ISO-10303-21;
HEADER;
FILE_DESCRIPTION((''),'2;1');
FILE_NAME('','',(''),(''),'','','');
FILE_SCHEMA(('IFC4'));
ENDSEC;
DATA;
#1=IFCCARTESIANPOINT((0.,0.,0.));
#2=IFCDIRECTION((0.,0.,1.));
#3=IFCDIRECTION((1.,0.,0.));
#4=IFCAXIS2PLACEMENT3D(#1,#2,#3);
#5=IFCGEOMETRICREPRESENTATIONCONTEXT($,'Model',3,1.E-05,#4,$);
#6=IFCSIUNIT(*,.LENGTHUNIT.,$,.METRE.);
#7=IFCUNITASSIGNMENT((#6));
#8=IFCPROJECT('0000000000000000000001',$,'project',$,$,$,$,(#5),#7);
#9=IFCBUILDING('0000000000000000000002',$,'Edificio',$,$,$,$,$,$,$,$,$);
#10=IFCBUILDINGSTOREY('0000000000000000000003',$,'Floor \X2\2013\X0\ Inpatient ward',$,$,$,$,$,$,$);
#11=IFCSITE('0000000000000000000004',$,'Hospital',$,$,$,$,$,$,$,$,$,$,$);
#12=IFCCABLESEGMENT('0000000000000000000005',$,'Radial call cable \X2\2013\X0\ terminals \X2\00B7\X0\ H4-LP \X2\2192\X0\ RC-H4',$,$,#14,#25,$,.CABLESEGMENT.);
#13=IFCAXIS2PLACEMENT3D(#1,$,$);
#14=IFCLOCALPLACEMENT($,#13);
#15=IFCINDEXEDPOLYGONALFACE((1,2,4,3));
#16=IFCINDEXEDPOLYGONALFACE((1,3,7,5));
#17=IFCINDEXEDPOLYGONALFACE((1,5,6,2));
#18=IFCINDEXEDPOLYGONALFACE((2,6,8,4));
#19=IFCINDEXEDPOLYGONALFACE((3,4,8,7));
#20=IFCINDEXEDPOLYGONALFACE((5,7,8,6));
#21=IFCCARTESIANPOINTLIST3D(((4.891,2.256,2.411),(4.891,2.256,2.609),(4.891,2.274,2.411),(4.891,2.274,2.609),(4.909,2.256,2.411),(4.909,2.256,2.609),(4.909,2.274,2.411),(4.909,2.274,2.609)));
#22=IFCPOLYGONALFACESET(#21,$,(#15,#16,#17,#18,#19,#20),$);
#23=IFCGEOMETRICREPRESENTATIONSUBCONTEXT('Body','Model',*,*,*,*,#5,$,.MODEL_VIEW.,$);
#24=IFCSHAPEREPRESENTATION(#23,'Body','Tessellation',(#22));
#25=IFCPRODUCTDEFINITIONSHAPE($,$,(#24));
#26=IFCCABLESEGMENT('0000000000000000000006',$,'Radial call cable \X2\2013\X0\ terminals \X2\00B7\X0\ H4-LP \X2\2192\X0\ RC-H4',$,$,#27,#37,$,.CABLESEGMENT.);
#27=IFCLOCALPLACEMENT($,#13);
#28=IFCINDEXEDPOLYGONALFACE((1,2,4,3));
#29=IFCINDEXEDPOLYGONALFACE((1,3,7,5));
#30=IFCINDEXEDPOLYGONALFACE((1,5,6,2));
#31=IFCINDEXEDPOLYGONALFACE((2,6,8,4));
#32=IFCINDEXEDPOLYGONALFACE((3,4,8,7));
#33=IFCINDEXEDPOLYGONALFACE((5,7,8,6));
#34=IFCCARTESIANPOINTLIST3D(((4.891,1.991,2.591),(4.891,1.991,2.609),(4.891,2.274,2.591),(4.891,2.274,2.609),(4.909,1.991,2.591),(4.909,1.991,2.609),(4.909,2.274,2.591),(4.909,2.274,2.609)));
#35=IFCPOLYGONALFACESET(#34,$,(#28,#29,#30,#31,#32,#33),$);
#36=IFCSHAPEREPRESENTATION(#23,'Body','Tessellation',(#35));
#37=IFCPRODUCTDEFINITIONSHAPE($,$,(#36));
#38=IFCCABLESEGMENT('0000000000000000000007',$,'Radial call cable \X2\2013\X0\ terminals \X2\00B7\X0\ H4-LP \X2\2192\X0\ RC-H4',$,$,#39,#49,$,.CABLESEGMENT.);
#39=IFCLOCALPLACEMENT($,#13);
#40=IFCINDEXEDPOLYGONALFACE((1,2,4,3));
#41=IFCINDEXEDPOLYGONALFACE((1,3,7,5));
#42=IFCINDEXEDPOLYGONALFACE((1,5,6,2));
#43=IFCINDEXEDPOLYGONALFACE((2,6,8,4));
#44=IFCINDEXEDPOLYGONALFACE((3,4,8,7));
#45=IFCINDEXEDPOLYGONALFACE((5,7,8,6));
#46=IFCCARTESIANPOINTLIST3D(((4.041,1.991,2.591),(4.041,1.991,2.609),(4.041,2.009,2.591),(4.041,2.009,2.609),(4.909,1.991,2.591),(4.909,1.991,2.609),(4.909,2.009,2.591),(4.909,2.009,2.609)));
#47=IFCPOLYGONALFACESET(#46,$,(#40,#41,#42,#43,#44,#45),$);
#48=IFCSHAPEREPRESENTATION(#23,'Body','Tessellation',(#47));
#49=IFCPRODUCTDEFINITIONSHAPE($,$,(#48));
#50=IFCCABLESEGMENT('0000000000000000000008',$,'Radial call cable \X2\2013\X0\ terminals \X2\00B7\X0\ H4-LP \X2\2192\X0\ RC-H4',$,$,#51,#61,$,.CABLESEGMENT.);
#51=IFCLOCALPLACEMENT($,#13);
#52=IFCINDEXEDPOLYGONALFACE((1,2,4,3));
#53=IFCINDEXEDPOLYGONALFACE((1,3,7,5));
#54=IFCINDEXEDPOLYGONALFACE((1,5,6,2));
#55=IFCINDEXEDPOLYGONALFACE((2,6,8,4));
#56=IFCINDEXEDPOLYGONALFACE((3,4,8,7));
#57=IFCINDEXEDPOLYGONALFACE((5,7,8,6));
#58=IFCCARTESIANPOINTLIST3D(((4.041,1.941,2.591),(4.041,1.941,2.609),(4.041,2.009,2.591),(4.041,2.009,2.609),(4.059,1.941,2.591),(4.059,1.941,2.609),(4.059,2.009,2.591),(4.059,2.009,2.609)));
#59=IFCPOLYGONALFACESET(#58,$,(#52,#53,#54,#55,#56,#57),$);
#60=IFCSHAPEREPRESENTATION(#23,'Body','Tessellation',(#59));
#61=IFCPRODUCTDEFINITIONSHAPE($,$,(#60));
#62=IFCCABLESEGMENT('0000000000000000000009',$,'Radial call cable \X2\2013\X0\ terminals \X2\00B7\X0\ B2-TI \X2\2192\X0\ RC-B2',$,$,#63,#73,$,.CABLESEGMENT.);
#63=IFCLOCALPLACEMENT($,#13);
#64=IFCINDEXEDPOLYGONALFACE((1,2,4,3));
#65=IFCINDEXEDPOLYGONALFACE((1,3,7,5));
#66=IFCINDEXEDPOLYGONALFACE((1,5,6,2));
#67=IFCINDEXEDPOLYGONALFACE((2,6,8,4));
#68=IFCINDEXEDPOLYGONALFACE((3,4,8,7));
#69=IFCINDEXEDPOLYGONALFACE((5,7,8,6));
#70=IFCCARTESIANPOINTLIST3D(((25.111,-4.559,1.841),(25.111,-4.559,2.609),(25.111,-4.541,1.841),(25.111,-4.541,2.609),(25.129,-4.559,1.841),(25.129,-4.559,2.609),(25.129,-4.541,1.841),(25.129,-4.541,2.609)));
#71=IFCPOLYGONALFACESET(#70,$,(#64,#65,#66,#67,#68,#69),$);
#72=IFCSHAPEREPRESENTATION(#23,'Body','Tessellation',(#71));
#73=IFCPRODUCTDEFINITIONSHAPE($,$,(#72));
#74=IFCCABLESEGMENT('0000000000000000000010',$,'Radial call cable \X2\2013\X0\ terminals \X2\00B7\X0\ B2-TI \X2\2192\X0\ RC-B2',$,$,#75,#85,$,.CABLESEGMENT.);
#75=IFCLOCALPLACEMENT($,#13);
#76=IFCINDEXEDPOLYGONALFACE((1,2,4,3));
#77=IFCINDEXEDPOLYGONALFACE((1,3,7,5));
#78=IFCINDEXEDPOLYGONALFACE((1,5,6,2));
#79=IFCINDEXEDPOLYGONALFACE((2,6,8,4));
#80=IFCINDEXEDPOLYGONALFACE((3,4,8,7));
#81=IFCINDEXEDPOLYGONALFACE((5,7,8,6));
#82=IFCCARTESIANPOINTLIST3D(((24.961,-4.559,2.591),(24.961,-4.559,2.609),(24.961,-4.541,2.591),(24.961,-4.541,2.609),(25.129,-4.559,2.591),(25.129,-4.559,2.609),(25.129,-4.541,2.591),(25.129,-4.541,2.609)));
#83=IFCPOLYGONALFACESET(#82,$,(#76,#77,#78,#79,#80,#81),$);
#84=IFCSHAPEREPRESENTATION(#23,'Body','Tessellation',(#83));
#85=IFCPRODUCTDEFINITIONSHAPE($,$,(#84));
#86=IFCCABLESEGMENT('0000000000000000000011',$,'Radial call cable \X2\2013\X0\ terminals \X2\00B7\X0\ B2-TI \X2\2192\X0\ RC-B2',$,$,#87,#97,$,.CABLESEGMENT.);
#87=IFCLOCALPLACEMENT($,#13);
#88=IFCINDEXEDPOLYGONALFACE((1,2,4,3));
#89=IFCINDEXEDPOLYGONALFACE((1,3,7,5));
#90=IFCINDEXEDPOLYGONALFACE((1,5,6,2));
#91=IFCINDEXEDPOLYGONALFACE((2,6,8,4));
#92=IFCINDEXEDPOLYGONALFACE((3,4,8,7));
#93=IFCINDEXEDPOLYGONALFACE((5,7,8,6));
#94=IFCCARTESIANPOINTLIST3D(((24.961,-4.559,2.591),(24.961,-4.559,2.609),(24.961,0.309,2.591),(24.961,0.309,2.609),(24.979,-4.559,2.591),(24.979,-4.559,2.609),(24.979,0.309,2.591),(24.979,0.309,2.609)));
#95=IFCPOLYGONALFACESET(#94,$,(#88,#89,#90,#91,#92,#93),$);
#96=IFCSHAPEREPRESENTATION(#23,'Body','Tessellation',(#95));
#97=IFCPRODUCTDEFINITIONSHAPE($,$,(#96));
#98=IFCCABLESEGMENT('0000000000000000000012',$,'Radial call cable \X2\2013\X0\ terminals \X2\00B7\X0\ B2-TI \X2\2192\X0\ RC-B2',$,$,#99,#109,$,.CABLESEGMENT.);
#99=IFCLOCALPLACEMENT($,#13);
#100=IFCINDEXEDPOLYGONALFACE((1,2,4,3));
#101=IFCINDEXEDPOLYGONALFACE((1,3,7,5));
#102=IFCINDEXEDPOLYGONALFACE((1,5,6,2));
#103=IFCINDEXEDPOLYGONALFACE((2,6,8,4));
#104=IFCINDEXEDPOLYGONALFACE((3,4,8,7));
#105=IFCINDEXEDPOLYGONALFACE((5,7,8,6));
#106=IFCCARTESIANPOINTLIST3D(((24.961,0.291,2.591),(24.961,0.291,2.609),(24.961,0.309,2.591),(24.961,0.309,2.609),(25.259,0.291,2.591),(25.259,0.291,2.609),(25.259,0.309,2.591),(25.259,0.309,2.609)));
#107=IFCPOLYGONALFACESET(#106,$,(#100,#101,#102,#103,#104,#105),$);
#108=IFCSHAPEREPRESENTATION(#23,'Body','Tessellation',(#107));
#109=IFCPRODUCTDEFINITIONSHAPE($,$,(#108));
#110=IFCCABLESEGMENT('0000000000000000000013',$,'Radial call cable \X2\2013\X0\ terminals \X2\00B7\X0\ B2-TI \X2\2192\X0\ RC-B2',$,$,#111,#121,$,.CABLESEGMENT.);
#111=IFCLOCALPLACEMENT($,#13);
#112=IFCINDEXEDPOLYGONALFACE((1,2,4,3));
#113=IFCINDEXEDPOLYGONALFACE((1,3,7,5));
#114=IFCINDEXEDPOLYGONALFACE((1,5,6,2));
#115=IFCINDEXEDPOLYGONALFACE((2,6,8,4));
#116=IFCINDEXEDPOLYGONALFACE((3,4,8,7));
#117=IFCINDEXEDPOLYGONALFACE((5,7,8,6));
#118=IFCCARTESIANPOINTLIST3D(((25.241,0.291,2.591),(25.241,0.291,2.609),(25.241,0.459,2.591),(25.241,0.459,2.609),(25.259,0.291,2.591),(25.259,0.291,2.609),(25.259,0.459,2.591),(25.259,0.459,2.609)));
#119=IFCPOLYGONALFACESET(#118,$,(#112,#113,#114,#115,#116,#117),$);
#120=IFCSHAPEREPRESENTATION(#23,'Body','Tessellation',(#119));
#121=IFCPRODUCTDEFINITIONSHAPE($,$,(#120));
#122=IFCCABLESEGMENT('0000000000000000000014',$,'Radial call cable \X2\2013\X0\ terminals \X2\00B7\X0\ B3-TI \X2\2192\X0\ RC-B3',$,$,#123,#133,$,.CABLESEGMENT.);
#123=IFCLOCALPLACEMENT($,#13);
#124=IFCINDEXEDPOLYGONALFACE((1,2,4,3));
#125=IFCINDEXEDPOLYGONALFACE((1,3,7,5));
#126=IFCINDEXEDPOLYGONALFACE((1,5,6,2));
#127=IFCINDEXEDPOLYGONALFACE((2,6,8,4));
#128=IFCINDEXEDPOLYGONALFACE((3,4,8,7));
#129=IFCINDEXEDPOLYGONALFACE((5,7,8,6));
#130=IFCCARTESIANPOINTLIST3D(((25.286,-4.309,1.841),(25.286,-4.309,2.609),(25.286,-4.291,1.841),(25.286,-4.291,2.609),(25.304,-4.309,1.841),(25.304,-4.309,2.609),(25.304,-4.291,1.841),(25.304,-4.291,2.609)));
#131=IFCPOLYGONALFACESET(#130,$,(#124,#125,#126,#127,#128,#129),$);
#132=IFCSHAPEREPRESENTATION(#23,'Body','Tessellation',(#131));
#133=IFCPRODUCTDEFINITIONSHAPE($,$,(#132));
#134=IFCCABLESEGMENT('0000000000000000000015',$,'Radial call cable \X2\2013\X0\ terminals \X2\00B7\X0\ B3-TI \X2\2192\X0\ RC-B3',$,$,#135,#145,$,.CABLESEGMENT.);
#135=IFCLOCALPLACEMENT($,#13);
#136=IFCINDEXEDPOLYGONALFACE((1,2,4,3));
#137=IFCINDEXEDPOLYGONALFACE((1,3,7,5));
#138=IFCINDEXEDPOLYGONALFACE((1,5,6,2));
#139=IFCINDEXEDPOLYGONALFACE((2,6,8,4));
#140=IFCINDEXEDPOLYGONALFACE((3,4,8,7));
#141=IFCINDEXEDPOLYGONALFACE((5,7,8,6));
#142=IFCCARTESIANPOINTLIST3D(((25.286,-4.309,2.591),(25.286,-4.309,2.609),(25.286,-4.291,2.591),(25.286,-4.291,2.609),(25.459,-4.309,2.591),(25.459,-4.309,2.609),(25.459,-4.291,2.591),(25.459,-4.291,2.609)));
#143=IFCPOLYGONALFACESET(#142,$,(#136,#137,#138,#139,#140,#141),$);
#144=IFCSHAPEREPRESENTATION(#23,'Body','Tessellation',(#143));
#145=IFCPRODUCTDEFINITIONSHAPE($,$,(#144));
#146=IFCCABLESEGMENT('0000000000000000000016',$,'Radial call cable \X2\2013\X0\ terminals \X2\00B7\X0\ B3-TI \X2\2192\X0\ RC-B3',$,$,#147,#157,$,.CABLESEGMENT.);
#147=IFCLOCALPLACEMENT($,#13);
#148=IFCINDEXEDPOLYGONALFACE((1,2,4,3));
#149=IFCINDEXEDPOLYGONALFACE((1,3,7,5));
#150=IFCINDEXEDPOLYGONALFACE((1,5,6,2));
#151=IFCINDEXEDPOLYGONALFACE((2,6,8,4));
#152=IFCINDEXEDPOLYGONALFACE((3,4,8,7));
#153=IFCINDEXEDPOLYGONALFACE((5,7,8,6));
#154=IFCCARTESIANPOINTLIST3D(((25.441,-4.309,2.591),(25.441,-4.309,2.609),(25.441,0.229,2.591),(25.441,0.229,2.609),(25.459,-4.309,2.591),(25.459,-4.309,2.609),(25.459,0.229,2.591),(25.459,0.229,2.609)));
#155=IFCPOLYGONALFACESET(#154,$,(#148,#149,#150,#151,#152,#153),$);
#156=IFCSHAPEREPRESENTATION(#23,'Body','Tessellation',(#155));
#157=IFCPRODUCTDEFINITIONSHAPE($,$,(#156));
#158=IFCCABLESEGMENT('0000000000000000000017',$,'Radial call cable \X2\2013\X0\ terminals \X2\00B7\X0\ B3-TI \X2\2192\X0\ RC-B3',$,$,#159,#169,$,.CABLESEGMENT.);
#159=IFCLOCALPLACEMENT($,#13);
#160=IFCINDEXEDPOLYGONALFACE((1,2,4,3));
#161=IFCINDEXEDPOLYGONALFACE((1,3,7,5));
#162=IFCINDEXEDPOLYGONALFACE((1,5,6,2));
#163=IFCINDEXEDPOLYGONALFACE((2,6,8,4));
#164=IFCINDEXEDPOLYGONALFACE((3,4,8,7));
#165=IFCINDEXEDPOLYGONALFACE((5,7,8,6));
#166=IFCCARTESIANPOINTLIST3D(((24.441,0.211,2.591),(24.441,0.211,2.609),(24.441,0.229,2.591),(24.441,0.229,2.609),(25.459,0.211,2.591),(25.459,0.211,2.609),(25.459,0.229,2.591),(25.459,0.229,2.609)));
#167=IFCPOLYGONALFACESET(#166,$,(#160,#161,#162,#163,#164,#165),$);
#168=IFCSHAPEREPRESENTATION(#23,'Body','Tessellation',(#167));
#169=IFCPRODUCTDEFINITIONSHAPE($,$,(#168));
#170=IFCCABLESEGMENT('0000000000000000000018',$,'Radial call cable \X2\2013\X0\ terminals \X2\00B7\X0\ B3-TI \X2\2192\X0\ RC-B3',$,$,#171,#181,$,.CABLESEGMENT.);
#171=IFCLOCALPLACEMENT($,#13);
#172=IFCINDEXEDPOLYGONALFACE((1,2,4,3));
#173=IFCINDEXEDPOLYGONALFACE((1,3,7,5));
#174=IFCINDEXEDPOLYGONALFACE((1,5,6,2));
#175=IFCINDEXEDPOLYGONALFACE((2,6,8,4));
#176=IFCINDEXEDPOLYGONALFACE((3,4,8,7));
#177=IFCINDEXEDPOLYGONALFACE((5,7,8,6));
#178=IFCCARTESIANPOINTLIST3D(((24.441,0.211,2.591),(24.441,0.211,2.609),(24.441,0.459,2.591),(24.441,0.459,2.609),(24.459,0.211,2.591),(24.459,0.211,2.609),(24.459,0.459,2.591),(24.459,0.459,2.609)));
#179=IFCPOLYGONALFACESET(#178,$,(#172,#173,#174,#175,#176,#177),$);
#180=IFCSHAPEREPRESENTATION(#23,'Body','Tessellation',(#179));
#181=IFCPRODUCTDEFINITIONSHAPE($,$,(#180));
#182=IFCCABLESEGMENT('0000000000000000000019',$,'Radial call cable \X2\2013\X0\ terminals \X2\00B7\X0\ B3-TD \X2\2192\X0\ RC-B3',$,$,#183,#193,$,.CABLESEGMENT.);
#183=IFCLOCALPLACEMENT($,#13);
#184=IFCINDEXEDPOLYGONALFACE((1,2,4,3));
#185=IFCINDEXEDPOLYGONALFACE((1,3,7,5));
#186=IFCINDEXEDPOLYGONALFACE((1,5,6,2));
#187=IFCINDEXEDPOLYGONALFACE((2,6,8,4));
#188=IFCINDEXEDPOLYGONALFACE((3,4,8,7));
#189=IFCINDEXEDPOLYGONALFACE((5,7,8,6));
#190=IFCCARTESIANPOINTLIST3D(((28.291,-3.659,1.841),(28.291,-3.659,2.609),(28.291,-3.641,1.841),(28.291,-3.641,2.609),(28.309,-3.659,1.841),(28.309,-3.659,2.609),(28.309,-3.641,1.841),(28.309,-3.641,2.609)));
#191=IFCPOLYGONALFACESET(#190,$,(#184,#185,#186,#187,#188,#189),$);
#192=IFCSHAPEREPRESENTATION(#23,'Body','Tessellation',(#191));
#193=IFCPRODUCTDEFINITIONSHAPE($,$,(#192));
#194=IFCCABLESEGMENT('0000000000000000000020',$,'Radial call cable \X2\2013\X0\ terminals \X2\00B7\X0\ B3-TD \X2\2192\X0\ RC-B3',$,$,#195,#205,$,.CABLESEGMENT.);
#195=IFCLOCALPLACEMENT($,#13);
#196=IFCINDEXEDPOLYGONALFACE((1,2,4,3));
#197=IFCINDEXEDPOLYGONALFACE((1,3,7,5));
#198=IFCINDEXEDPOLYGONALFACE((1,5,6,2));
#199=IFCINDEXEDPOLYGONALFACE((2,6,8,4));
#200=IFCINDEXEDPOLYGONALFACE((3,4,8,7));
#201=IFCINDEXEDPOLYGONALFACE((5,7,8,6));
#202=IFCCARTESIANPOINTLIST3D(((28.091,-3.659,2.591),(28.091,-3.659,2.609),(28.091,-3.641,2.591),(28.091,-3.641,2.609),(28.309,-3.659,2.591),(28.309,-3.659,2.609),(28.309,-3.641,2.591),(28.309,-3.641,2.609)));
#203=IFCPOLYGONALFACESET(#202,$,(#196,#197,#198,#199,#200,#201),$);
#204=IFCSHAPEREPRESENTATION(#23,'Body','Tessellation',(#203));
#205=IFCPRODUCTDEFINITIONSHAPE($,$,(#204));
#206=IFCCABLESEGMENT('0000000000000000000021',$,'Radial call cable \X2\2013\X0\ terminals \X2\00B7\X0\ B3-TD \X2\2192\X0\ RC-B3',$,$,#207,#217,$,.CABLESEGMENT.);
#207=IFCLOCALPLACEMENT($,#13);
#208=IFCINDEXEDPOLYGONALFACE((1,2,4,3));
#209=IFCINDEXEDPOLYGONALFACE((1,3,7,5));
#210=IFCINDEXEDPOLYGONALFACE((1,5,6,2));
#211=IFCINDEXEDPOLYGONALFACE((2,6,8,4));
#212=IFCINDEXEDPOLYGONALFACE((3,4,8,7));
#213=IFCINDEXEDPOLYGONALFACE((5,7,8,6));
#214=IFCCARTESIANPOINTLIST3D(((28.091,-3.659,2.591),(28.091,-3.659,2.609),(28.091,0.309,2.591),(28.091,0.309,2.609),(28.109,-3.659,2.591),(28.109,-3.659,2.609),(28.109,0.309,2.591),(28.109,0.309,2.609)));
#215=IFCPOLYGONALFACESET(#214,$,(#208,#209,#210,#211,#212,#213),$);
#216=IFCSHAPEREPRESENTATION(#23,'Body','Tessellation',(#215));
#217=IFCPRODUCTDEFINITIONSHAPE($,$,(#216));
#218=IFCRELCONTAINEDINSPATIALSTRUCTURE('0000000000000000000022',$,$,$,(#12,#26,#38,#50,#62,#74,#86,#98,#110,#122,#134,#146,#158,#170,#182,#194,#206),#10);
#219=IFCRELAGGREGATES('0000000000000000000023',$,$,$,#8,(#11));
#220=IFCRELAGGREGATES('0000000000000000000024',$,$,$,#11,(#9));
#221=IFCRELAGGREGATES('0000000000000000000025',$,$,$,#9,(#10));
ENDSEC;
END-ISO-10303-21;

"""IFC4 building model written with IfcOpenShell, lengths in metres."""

from ifc_helpers import new_model, si_unit, frame, origin_with_axes, context, subcontext, project, spatial, line, indexed_curve, outline, extrude, element, save


model = new_model("IFC4")

# Units and contexts
model_context = context("Model", 3, precision=1e-05, world=origin_with_axes())
body_context = subcontext(model_context, "Body", "Model", "MODEL_VIEW")
ifc_project = project(units=[si_unit("LENGTHUNIT", "METRE")], contexts=[model_context])

# Site, building, storey
site = spatial("IfcSite", under=ifc_project, Name="Hospital")
building = spatial("IfcBuilding", under=site, Name="Edificio")
storey = spatial("IfcBuildingStorey", under=building, Name="Floor – Inpatient ward")

# Cable segments
element("IfcCableSegment", 1, inside=storey, Name="Radial call cable – terminals · H4-LP → RC-H4", PredefinedType="CABLESEGMENT", context=body_context, shape_type="SweptSolid", body=[
    extrude(outline(indexed_curve([(0.0, 0.0), (0.018, 0.0), (0.018, 0.018), (0.0, 0.018)], segments=[line(1, 2, 3, 4, 1)])), frame((4.891, 2.256, 2.411), z_axis=(0.0, 0.0, 1.0), x_axis=(1.0, 0.0, 0.0)), (0.0, 0.0, 1.0), 0.198),
])
element("IfcCableSegment", 2, inside=storey, Name="Radial call cable – terminals · H4-LP → RC-H4", PredefinedType="CABLESEGMENT", context=body_context, shape_type="SweptSolid", body=[
    extrude(outline(indexed_curve([(0.0, 0.0), (0.018, 0.0), (0.018, 0.283), (0.0, 0.283)], segments=[line(1, 2, 3, 4, 1)])), frame((4.891, 1.991, 2.591), z_axis=(0.0, 0.0, 1.0), x_axis=(1.0, 0.0, 0.0)), (0.0, 0.0, 1.0), 0.018),
])
element("IfcCableSegment", 3, inside=storey, Name="Radial call cable – terminals · H4-LP → RC-H4", PredefinedType="CABLESEGMENT", context=body_context, shape_type="SweptSolid", body=[
    extrude(outline(indexed_curve([(0.0, 0.0), (0.868, 0.0), (0.868, 0.018), (0.0, 0.018)], segments=[line(1, 2, 3, 4, 1)])), frame((4.041, 1.991, 2.591), z_axis=(0.0, 0.0, 1.0), x_axis=(1.0, 0.0, 0.0)), (0.0, 0.0, 1.0), 0.018),
])
element("IfcCableSegment", 4, inside=storey, Name="Radial call cable – terminals · H4-LP → RC-H4", PredefinedType="CABLESEGMENT", context=body_context, shape_type="SweptSolid", body=[
    extrude(outline(indexed_curve([(0.0, 0.0), (0.018, 0.0), (0.018, 0.068), (0.0, 0.068)], segments=[line(1, 2, 3, 4, 1)])), frame((4.041, 1.941, 2.591), z_axis=(0.0, 0.0, 1.0), x_axis=(1.0, 0.0, 0.0)), (0.0, 0.0, 1.0), 0.018),
])
element("IfcCableSegment", 5, inside=storey, Name="Radial call cable – terminals · B2-TI → RC-B2", PredefinedType="CABLESEGMENT", context=body_context, shape_type="SweptSolid", body=[
    extrude(outline(indexed_curve([(0.0, 0.0), (0.018, 0.0), (0.018, 0.018), (0.0, 0.018)], segments=[line(1, 2, 3, 4, 1)])), frame((25.111, -4.559, 1.841), z_axis=(0.0, 0.0, 1.0), x_axis=(1.0, 0.0, 0.0)), (0.0, 0.0, 1.0), 0.768),
])
element("IfcCableSegment", 6, inside=storey, Name="Radial call cable – terminals · B2-TI → RC-B2", PredefinedType="CABLESEGMENT", context=body_context, shape_type="SweptSolid", body=[
    extrude(outline(indexed_curve([(0.0, 0.0), (0.168, 0.0), (0.168, 0.018), (0.0, 0.018)], segments=[line(1, 2, 3, 4, 1)])), frame((24.961, -4.559, 2.591), z_axis=(0.0, 0.0, 1.0), x_axis=(1.0, 0.0, 0.0)), (0.0, 0.0, 1.0), 0.018),
])
element("IfcCableSegment", 7, inside=storey, Name="Radial call cable – terminals · B2-TI → RC-B2", PredefinedType="CABLESEGMENT", context=body_context, shape_type="SweptSolid", body=[
    extrude(outline(indexed_curve([(0.0, 0.0), (0.018, 0.0), (0.018, 4.868), (0.0, 4.868)], segments=[line(1, 2, 3, 4, 1)])), frame((24.961, -4.559, 2.591), z_axis=(0.0, 0.0, 1.0), x_axis=(1.0, 0.0, 0.0)), (0.0, 0.0, 1.0), 0.018),
])
element("IfcCableSegment", 8, inside=storey, Name="Radial call cable – terminals · B2-TI → RC-B2", PredefinedType="CABLESEGMENT", context=body_context, shape_type="SweptSolid", body=[
    extrude(outline(indexed_curve([(0.0, 0.0), (0.298, 0.0), (0.298, 0.018), (0.0, 0.018)], segments=[line(1, 2, 3, 4, 1)])), frame((24.961, 0.291, 2.591), z_axis=(0.0, 0.0, 1.0), x_axis=(1.0, 0.0, 0.0)), (0.0, 0.0, 1.0), 0.018),
])
element("IfcCableSegment", 9, inside=storey, Name="Radial call cable – terminals · B2-TI → RC-B2", PredefinedType="CABLESEGMENT", context=body_context, shape_type="SweptSolid", body=[
    extrude(outline(indexed_curve([(0.0, 0.0), (0.018, 0.0), (0.018, 0.168), (0.0, 0.168)], segments=[line(1, 2, 3, 4, 1)])), frame((25.241, 0.291, 2.591), z_axis=(0.0, 0.0, 1.0), x_axis=(1.0, 0.0, 0.0)), (0.0, 0.0, 1.0), 0.018),
])
element("IfcCableSegment", 10, inside=storey, Name="Radial call cable – terminals · B3-TI → RC-B3", PredefinedType="CABLESEGMENT", context=body_context, shape_type="SweptSolid", body=[
    extrude(outline(indexed_curve([(0.0, 0.0), (0.018, 0.0), (0.018, 0.018), (0.0, 0.018)], segments=[line(1, 2, 3, 4, 1)])), frame((25.286, -4.309, 1.841), z_axis=(0.0, 0.0, 1.0), x_axis=(1.0, 0.0, 0.0)), (0.0, 0.0, 1.0), 0.768),
])
element("IfcCableSegment", 11, inside=storey, Name="Radial call cable – terminals · B3-TI → RC-B3", PredefinedType="CABLESEGMENT", context=body_context, shape_type="SweptSolid", body=[
    extrude(outline(indexed_curve([(0.0, 0.0), (0.173, 0.0), (0.173, 0.018), (0.0, 0.018)], segments=[line(1, 2, 3, 4, 1)])), frame((25.286, -4.309, 2.591), z_axis=(0.0, 0.0, 1.0), x_axis=(1.0, 0.0, 0.0)), (0.0, 0.0, 1.0), 0.018),
])
element("IfcCableSegment", 12, inside=storey, Name="Radial call cable – terminals · B3-TI → RC-B3", PredefinedType="CABLESEGMENT", context=body_context, shape_type="SweptSolid", body=[
    extrude(outline(indexed_curve([(0.0, 0.0), (0.018, 0.0), (0.018, 4.538), (0.0, 4.538)], segments=[line(1, 2, 3, 4, 1)])), frame((25.441, -4.309, 2.591), z_axis=(0.0, 0.0, 1.0), x_axis=(1.0, 0.0, 0.0)), (0.0, 0.0, 1.0), 0.018),
])
element("IfcCableSegment", 13, inside=storey, Name="Radial call cable – terminals · B3-TI → RC-B3", PredefinedType="CABLESEGMENT", context=body_context, shape_type="SweptSolid", body=[
    extrude(outline(indexed_curve([(0.0, 0.0), (1.018, 0.0), (1.018, 0.018), (0.0, 0.018)], segments=[line(1, 2, 3, 4, 1)])), frame((24.441, 0.211, 2.591), z_axis=(0.0, 0.0, 1.0), x_axis=(1.0, 0.0, 0.0)), (0.0, 0.0, 1.0), 0.018),
])
element("IfcCableSegment", 14, inside=storey, Name="Radial call cable – terminals · B3-TI → RC-B3", PredefinedType="CABLESEGMENT", context=body_context, shape_type="SweptSolid", body=[
    extrude(outline(indexed_curve([(0.0, 0.0), (0.018, 0.0), (0.018, 0.248), (0.0, 0.248)], segments=[line(1, 2, 3, 4, 1)])), frame((24.441, 0.211, 2.591), z_axis=(0.0, 0.0, 1.0), x_axis=(1.0, 0.0, 0.0)), (0.0, 0.0, 1.0), 0.018),
])
element("IfcCableSegment", 15, inside=storey, Name="Radial call cable – terminals · B3-TD → RC-B3", PredefinedType="CABLESEGMENT", context=body_context, shape_type="SweptSolid", body=[
    extrude(outline(indexed_curve([(0.0, 0.0), (0.018, 0.0), (0.018, 0.018), (0.0, 0.018)], segments=[line(1, 2, 3, 4, 1)])), frame((28.291, -3.659, 1.841), z_axis=(0.0, 0.0, 1.0), x_axis=(1.0, 0.0, 0.0)), (0.0, 0.0, 1.0), 0.768),
])
element("IfcCableSegment", 16, inside=storey, Name="Radial call cable – terminals · B3-TD → RC-B3", PredefinedType="CABLESEGMENT", context=body_context, shape_type="SweptSolid", body=[
    extrude(outline(indexed_curve([(0.0, 0.0), (0.218, 0.0), (0.218, 0.018), (0.0, 0.018)], segments=[line(1, 2, 3, 4, 1)])), frame((28.091, -3.659, 2.591), z_axis=(0.0, 0.0, 1.0), x_axis=(1.0, 0.0, 0.0)), (0.0, 0.0, 1.0), 0.018),
])
element("IfcCableSegment", 17, inside=storey, Name="Radial call cable – terminals · B3-TD → RC-B3", PredefinedType="CABLESEGMENT", context=body_context, shape_type="SweptSolid", body=[
    extrude(outline(indexed_curve([(0.0, 0.0), (0.018, 0.0), (0.018, 3.968), (0.0, 3.968)], segments=[line(1, 2, 3, 4, 1)])), frame((28.091, -3.659, 2.591), z_axis=(0.0, 0.0, 1.0), x_axis=(1.0, 0.0, 0.0)), (0.0, 0.0, 1.0), 0.018),
])

save(model, "model.ifc")
